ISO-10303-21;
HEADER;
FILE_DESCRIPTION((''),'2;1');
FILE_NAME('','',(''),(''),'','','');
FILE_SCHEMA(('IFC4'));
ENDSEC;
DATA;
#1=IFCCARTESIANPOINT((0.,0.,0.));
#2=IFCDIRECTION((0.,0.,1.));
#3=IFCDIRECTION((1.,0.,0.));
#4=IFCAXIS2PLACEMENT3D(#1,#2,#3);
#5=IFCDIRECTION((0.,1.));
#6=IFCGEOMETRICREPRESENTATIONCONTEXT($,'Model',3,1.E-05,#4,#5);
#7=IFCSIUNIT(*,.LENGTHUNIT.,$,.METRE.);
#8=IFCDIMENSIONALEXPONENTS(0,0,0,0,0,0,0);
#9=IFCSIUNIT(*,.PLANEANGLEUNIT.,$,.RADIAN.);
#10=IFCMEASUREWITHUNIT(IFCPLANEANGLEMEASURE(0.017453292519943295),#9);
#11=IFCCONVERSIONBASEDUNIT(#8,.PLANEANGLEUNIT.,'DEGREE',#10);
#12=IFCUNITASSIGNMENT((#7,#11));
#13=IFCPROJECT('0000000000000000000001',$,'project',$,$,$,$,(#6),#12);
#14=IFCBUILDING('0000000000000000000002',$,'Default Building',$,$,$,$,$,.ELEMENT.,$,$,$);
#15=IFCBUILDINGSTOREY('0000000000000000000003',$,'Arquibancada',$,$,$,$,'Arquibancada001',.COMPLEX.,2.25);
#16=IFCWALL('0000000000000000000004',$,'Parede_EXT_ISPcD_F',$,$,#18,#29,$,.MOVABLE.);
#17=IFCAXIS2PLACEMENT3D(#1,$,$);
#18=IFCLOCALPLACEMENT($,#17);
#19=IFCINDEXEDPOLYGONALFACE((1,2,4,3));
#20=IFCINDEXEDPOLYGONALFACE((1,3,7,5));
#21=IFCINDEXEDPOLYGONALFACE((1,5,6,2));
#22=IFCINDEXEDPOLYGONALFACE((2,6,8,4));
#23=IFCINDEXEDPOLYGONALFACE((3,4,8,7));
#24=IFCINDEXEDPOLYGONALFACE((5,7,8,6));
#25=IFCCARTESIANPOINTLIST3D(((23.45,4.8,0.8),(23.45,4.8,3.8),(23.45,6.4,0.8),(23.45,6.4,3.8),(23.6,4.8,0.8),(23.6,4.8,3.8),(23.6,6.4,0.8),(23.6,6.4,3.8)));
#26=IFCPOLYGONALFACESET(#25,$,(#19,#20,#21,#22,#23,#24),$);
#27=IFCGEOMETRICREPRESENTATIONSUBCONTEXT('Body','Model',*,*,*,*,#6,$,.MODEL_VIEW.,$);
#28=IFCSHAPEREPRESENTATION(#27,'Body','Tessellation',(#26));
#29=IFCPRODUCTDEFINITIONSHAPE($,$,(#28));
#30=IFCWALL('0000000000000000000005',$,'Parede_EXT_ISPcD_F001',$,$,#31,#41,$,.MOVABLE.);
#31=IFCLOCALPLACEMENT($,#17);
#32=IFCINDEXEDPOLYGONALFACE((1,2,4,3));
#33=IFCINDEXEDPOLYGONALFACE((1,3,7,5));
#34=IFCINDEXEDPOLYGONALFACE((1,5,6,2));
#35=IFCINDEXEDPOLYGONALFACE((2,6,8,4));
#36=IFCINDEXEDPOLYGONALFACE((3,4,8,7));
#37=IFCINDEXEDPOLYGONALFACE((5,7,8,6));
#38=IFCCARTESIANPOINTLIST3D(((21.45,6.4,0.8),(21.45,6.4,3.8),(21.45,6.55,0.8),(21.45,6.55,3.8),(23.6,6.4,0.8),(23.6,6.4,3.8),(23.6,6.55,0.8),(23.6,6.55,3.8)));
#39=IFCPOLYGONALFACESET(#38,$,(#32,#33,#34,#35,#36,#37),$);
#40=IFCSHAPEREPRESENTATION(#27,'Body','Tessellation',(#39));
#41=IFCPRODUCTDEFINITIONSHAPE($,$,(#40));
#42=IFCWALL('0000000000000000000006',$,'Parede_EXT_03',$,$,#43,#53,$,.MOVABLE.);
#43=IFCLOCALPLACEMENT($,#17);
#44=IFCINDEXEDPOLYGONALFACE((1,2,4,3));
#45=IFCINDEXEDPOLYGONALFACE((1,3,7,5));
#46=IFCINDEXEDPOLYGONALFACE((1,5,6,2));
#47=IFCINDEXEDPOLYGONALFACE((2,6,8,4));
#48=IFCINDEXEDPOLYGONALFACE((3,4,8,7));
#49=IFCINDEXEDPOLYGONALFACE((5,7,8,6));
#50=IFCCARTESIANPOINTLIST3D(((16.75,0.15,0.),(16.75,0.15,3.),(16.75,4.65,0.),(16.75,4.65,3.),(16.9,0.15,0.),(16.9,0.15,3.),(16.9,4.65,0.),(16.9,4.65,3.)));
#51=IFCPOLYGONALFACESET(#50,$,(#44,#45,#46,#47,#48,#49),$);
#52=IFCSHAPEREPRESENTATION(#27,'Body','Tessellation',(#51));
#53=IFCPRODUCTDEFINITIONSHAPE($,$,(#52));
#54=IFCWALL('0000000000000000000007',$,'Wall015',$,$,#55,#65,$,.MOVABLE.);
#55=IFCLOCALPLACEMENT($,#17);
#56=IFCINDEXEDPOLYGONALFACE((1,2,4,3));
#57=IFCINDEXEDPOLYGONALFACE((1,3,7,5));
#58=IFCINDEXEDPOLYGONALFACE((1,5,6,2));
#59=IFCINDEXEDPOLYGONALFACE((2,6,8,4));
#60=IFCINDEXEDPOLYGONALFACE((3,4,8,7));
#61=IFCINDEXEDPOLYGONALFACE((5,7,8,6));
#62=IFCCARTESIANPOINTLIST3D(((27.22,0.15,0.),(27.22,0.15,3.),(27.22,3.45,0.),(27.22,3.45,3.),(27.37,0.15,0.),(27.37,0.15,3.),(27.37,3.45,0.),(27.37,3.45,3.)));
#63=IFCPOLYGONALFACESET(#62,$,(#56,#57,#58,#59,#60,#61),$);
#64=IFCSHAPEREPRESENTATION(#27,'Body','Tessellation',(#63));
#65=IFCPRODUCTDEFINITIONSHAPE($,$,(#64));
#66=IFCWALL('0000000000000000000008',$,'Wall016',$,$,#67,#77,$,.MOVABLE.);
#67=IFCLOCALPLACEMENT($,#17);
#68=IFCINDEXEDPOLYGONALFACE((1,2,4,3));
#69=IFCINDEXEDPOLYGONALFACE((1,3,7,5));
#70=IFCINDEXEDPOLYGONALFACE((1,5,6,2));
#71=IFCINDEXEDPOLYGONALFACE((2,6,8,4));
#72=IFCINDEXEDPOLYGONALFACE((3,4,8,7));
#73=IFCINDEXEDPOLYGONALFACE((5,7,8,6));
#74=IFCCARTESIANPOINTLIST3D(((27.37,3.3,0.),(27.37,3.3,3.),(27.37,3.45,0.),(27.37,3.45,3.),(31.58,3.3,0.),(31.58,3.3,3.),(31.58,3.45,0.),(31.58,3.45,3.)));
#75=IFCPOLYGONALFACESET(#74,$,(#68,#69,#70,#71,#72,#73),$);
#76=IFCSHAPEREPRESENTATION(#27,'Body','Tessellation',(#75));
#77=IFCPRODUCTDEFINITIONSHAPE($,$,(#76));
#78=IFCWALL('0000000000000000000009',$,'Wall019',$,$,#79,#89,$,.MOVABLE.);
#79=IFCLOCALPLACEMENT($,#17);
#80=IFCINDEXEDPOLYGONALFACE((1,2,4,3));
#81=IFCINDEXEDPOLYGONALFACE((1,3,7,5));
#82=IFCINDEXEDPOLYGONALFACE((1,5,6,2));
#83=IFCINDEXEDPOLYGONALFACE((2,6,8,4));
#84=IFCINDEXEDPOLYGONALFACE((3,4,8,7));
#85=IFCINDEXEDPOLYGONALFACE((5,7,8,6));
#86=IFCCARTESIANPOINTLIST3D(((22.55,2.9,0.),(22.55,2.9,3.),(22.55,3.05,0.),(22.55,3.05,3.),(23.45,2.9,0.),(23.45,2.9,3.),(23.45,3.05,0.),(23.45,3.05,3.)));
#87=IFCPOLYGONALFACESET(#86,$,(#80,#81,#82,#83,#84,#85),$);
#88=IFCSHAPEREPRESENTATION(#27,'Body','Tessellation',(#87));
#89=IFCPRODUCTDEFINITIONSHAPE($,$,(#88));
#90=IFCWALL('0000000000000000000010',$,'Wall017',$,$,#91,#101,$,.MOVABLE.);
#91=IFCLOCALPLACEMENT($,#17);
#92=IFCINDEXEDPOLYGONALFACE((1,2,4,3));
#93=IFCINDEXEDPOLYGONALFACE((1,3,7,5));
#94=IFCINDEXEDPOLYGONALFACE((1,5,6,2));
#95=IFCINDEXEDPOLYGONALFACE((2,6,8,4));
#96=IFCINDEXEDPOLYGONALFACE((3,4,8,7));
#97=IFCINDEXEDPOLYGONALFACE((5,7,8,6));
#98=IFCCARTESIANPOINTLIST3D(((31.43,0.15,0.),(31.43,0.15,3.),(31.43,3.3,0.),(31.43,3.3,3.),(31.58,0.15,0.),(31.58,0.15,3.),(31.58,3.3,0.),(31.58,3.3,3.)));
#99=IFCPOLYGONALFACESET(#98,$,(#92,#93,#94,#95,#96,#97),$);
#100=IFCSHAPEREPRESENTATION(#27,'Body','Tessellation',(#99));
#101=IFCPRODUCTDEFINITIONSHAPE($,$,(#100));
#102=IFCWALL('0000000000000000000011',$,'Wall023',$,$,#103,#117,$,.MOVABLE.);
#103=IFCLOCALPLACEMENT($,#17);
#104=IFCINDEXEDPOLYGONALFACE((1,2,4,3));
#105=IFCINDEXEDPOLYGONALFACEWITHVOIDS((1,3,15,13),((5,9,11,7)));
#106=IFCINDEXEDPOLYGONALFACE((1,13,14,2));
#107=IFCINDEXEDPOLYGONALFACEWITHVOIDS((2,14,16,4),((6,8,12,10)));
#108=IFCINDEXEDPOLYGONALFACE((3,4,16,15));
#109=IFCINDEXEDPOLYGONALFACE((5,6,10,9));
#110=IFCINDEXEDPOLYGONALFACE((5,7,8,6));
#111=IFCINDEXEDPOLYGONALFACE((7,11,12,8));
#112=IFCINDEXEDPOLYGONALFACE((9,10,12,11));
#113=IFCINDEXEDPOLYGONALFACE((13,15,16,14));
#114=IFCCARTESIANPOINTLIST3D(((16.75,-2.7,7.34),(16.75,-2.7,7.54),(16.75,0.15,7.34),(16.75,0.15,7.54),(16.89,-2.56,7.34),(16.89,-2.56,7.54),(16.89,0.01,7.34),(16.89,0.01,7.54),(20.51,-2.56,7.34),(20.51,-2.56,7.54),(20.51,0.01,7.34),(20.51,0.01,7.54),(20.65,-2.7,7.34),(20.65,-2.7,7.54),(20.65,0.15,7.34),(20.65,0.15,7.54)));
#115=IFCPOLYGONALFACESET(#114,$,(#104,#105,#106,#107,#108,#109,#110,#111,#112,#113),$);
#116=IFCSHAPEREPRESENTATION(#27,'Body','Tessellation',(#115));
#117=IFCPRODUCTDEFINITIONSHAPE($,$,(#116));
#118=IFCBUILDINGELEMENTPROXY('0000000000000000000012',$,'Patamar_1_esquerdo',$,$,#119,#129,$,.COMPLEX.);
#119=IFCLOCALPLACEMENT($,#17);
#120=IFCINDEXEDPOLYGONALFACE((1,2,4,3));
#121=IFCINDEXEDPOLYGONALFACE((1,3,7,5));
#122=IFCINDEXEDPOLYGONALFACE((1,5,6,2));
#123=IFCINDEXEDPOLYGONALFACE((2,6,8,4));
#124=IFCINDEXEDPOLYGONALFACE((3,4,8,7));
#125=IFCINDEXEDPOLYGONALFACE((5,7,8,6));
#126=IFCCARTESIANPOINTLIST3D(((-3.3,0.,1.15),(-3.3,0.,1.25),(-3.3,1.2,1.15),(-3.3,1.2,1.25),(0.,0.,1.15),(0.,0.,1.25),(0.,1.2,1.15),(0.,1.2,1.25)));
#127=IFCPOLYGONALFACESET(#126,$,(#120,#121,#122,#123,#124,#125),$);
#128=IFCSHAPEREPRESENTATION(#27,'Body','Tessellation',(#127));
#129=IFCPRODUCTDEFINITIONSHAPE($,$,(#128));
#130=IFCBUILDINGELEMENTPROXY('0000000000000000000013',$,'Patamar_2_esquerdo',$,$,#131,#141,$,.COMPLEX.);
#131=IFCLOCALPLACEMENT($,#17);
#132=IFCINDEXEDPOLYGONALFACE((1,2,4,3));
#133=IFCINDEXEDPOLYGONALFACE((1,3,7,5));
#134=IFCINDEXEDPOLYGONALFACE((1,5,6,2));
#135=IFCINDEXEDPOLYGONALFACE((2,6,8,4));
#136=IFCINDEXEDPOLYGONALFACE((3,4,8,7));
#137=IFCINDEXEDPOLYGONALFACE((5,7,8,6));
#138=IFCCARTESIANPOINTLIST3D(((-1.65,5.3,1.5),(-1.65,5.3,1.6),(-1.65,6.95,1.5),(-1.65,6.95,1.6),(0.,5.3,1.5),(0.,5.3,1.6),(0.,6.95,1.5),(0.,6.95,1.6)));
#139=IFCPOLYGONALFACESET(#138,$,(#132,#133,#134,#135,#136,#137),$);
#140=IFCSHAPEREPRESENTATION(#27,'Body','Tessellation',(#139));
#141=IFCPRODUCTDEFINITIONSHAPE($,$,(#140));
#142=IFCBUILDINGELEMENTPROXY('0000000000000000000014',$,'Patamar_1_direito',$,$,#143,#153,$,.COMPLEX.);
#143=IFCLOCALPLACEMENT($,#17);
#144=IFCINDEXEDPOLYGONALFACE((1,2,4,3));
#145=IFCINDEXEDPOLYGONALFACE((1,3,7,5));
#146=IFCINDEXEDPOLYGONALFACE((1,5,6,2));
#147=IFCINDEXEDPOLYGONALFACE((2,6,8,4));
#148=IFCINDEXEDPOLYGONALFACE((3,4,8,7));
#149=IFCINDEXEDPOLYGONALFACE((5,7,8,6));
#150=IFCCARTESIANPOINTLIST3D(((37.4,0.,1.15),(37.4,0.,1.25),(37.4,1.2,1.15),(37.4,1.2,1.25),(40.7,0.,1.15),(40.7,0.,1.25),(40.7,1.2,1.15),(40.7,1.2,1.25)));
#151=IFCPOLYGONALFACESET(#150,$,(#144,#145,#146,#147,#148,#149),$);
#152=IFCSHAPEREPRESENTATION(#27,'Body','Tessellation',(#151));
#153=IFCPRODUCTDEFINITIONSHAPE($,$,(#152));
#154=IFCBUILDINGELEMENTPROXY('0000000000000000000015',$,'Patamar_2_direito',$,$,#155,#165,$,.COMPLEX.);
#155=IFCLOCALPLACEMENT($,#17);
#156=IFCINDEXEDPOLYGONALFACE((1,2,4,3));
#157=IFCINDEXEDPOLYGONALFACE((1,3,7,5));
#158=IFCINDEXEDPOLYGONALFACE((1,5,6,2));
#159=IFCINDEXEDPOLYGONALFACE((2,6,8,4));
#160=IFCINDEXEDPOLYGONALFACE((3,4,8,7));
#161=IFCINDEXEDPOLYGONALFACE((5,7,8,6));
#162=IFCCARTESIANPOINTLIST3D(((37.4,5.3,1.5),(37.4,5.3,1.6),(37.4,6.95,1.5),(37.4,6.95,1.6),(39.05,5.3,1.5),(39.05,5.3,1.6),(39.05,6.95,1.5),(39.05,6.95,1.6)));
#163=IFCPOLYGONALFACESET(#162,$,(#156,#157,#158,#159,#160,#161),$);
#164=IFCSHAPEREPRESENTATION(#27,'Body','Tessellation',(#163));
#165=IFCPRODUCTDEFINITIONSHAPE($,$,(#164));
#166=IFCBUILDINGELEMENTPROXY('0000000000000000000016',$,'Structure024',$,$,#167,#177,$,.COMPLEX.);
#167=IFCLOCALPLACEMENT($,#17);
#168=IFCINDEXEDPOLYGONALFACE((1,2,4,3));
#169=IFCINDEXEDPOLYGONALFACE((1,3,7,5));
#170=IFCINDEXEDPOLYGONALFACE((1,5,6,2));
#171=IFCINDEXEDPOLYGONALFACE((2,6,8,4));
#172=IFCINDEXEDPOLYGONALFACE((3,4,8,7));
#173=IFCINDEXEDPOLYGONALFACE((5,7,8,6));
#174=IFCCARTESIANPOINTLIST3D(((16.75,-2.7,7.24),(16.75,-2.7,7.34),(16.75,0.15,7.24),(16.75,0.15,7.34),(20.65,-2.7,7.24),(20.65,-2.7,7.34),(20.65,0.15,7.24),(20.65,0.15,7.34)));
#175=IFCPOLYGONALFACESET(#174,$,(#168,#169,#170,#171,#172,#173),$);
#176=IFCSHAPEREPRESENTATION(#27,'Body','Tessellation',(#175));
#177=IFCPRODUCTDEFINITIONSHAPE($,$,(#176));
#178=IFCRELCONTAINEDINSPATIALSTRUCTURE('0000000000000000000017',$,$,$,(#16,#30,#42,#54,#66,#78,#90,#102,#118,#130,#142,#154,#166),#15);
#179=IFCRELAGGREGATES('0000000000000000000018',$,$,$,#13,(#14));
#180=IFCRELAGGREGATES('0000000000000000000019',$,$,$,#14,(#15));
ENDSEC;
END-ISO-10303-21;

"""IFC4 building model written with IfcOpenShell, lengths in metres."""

from ifc_helpers import new_model, entity, si_unit, converted_unit, direction, frame, frame_2d, origin_with_axes, origin_2d_with_axis, place, context, subcontext, project, spatial, polyline, rectangle, outline, extrude, source, transform, mapped, element, save


model = new_model("IFC4")

# Units and contexts
model_context = context("Model", 3, precision=1e-05, world=origin_with_axes(), true_north=direction((0.0, 1.0)))
body_context = subcontext(model_context, "Body", "Model", "MODEL_VIEW")
ifc_project = project(units=[si_unit("LENGTHUNIT", "METRE"), converted_unit("PLANEANGLEUNIT", "DEGREE", entity("IfcPlaneAngleMeasure", 0.017453292519943295), si_unit("PLANEANGLEUNIT", "RADIAN"), dimensions=[0, 0, 0, 0, 0, 0, 0])], contexts=[model_context])

# Building, storey
building = spatial("IfcBuilding", under=ifc_project, Name="Default Building", CompositionType="ELEMENT")
storey = spatial("IfcBuildingStorey", under=building, Name="Arquibancada", LongName="Arquibancada001", CompositionType="COMPLEX", Elevation=2.25)

# Walls
shared_shape_1 = source(origin_with_axes(), body_context, "Body", "SweptSolid", [
    extrude(rectangle(XDim=1.6, YDim=0.15, at=frame_2d((0.0, 0.0), x_axis=(0.0, -1.0))), frame((23.525, 5.6, 0.0), z_axis=(0.0, 0.0, 1.0), x_axis=(1.0, 0.0, 0.0)), (0.0, 0.0, 1.0), 3.0),
])
placement = place(None, origin_with_axes())
element("IfcWall", 1, at=placement, inside=storey, Name="Parede_EXT_ISPcD_F", PredefinedType="MOVABLE", context=body_context, shape_type="MappedRepresentation", body=[
    mapped(shared_shape_1, transform((0.0, 0.0, 0.8), x_axis=(1.0, 0.0, 0.0), y_axis=(0.0, 1.0, 0.0), z_axis=(0.0, 0.0, 1.0), scale=1.0)),
])
shared_shape_2 = source(origin_with_axes(), body_context, "Body", "SweptSolid", [
    extrude(rectangle(XDim=2.15, YDim=0.15, at=frame_2d((0.0, 0.0), x_axis=(1.0, 0.0))), frame((22.525, 6.475, 0.0), z_axis=(0.0, 0.0, 1.0), x_axis=(1.0, 0.0, 0.0)), (0.0, 0.0, 1.0), 3.0),
])
element("IfcWall", 2, at=placement, inside=storey, Name="Parede_EXT_ISPcD_F001", PredefinedType="MOVABLE", context=body_context, shape_type="MappedRepresentation", body=[
    mapped(shared_shape_2, transform((0.0, 0.0, 0.8), x_axis=(1.0, 0.0, 0.0), y_axis=(0.0, 1.0, 0.0), z_axis=(0.0, 0.0, 1.0), scale=1.0)),
])
element("IfcWall", 3, at=placement, inside=storey, Name="Parede_EXT_03", PredefinedType="MOVABLE", context=body_context, shape_type="SweptSolid", body=[
    extrude(rectangle(XDim=4.5, YDim=0.15, at=frame_2d((0.0, 0.0), x_axis=(0.0, -1.0))), frame((16.825, 2.4, 0.0), z_axis=(0.0, 0.0, 1.0), x_axis=(1.0, 0.0, 0.0)), (0.0, 0.0, 1.0), 3.0),
])
element("IfcWall", 4, at=placement, inside=storey, Name="Wall015", PredefinedType="MOVABLE", context=body_context, shape_type="SweptSolid", body=[
    extrude(rectangle(XDim=3.3, YDim=0.15, at=frame_2d((0.0, 0.0), x_axis=(0.0, 1.0))), frame((27.295, 1.8, 0.0), z_axis=(0.0, 0.0, 1.0), x_axis=(1.0, 0.0, 0.0)), (0.0, 0.0, 1.0), 3.0),
])
element("IfcWall", 5, at=placement, inside=storey, Name="Wall016", PredefinedType="MOVABLE", context=body_context, shape_type="SweptSolid", body=[
    extrude(rectangle(XDim=4.21, YDim=0.15, at=origin_2d_with_axis()), frame((29.475, 3.375, 0.0), z_axis=(0.0, 0.0, 1.0), x_axis=(1.0, 0.0, 0.0)), (0.0, 0.0, 1.0), 3.0),
])
element("IfcWall", 6, at=placement, inside=storey, Name="Wall019", PredefinedType="MOVABLE", context=body_context, shape_type="SweptSolid", body=[
    extrude(rectangle(XDim=0.9, YDim=0.15, at=frame_2d((0.0, 0.0), x_axis=(-1.0, 0.0))), frame((23.0, 2.975, 0.0), z_axis=(0.0, 0.0, 1.0), x_axis=(1.0, 0.0, 0.0)), (0.0, 0.0, 1.0), 3.0),
])
element("IfcWall", 7, at=placement, inside=storey, Name="Wall017", PredefinedType="MOVABLE", context=body_context, shape_type="SweptSolid", body=[
    extrude(rectangle(XDim=3.15, YDim=0.15, at=frame_2d((0.0, 0.0), x_axis=(0.0, -1.0))), frame((31.505, 1.725, 0.0), z_axis=(0.0, 0.0, 1.0), x_axis=(1.0, 0.0, 0.0)), (0.0, 0.0, 1.0), 3.0),
])
element("IfcWall", 8, at=placement, inside=storey, Name="Wall023", PredefinedType="MOVABLE", context=body_context, shape_type="SweptSolid", body=[
    extrude(outline(polyline([(-1.95, -1.425), (1.95, -1.425), (1.95, 1.425), (-1.95, 1.425), (-1.95, -1.425)]), holes=[polyline([(1.81, -1.285), (1.81, 1.285), (-1.81, 1.285), (-1.81, -1.285), (1.81, -1.285)])]), frame((18.7, -1.275, 7.34), z_axis=(0.0, 0.0, 1.0), x_axis=(1.0, 0.0, 0.0)), (0.0, 0.0, 1.0), 0.2),
])

# Building element proxies
element("IfcBuildingElementProxy", 9, at=placement, inside=storey, Name="Patamar_1_esquerdo", PredefinedType="COMPLEX", context=body_context, shape_type="SweptSolid", body=[
    extrude(rectangle(XDim=3.3, YDim=1.2, at=frame_2d((0.0, 0.0), x_axis=(-1.0, 0.0))), frame((-1.65, 0.6, 1.25), z_axis=(0.0, 0.0, 1.0), x_axis=(1.0, 0.0, 0.0)), (0.0, 0.0, -1.0), 0.1),
])
element("IfcBuildingElementProxy", 10, at=placement, inside=storey, Name="Patamar_2_esquerdo", PredefinedType="COMPLEX", context=body_context, shape_type="SweptSolid", body=[
    extrude(rectangle(XDim=1.65, YDim=1.65, at=frame_2d((0.0, 0.0), x_axis=(0.0, -1.0))), frame((-0.825, 6.125, 1.6), z_axis=(0.0, 0.0, 1.0), x_axis=(1.0, 0.0, 0.0)), (0.0, 0.0, -1.0), 0.1),
])
element("IfcBuildingElementProxy", 11, at=placement, inside=storey, Name="Patamar_1_direito", PredefinedType="COMPLEX", context=body_context, shape_type="SweptSolid", body=[
    extrude(rectangle(XDim=1.2, YDim=3.3, at=frame_2d((0.0, 0.0), x_axis=(0.0, 1.0))), frame((39.05, 0.6, 1.25), z_axis=(0.0, 0.0, 1.0), x_axis=(1.0, 0.0, 0.0)), (0.0, 0.0, -1.0), 0.1),
])
element("IfcBuildingElementProxy", 12, at=placement, inside=storey, Name="Patamar_2_direito", PredefinedType="COMPLEX", context=body_context, shape_type="SweptSolid", body=[
    extrude(rectangle(XDim=1.65, YDim=1.65, at=origin_2d_with_axis()), frame((38.225, 6.125, 1.6), z_axis=(0.0, 0.0, 1.0), x_axis=(1.0, 0.0, 0.0)), (0.0, 0.0, -1.0), 0.1),
])
element("IfcBuildingElementProxy", 13, at=placement, inside=storey, Name="Structure024", PredefinedType="COMPLEX", context=body_context, shape_type="SweptSolid", body=[
    extrude(rectangle(XDim=3.9, YDim=2.85, at=origin_2d_with_axis()), frame((18.7, -1.275, 7.24), z_axis=(0.0, 0.0, 1.0), x_axis=(1.0, 0.0, 0.0)), (0.0, 0.0, 1.0), 0.1),
])

save(model, "model.ifc")
